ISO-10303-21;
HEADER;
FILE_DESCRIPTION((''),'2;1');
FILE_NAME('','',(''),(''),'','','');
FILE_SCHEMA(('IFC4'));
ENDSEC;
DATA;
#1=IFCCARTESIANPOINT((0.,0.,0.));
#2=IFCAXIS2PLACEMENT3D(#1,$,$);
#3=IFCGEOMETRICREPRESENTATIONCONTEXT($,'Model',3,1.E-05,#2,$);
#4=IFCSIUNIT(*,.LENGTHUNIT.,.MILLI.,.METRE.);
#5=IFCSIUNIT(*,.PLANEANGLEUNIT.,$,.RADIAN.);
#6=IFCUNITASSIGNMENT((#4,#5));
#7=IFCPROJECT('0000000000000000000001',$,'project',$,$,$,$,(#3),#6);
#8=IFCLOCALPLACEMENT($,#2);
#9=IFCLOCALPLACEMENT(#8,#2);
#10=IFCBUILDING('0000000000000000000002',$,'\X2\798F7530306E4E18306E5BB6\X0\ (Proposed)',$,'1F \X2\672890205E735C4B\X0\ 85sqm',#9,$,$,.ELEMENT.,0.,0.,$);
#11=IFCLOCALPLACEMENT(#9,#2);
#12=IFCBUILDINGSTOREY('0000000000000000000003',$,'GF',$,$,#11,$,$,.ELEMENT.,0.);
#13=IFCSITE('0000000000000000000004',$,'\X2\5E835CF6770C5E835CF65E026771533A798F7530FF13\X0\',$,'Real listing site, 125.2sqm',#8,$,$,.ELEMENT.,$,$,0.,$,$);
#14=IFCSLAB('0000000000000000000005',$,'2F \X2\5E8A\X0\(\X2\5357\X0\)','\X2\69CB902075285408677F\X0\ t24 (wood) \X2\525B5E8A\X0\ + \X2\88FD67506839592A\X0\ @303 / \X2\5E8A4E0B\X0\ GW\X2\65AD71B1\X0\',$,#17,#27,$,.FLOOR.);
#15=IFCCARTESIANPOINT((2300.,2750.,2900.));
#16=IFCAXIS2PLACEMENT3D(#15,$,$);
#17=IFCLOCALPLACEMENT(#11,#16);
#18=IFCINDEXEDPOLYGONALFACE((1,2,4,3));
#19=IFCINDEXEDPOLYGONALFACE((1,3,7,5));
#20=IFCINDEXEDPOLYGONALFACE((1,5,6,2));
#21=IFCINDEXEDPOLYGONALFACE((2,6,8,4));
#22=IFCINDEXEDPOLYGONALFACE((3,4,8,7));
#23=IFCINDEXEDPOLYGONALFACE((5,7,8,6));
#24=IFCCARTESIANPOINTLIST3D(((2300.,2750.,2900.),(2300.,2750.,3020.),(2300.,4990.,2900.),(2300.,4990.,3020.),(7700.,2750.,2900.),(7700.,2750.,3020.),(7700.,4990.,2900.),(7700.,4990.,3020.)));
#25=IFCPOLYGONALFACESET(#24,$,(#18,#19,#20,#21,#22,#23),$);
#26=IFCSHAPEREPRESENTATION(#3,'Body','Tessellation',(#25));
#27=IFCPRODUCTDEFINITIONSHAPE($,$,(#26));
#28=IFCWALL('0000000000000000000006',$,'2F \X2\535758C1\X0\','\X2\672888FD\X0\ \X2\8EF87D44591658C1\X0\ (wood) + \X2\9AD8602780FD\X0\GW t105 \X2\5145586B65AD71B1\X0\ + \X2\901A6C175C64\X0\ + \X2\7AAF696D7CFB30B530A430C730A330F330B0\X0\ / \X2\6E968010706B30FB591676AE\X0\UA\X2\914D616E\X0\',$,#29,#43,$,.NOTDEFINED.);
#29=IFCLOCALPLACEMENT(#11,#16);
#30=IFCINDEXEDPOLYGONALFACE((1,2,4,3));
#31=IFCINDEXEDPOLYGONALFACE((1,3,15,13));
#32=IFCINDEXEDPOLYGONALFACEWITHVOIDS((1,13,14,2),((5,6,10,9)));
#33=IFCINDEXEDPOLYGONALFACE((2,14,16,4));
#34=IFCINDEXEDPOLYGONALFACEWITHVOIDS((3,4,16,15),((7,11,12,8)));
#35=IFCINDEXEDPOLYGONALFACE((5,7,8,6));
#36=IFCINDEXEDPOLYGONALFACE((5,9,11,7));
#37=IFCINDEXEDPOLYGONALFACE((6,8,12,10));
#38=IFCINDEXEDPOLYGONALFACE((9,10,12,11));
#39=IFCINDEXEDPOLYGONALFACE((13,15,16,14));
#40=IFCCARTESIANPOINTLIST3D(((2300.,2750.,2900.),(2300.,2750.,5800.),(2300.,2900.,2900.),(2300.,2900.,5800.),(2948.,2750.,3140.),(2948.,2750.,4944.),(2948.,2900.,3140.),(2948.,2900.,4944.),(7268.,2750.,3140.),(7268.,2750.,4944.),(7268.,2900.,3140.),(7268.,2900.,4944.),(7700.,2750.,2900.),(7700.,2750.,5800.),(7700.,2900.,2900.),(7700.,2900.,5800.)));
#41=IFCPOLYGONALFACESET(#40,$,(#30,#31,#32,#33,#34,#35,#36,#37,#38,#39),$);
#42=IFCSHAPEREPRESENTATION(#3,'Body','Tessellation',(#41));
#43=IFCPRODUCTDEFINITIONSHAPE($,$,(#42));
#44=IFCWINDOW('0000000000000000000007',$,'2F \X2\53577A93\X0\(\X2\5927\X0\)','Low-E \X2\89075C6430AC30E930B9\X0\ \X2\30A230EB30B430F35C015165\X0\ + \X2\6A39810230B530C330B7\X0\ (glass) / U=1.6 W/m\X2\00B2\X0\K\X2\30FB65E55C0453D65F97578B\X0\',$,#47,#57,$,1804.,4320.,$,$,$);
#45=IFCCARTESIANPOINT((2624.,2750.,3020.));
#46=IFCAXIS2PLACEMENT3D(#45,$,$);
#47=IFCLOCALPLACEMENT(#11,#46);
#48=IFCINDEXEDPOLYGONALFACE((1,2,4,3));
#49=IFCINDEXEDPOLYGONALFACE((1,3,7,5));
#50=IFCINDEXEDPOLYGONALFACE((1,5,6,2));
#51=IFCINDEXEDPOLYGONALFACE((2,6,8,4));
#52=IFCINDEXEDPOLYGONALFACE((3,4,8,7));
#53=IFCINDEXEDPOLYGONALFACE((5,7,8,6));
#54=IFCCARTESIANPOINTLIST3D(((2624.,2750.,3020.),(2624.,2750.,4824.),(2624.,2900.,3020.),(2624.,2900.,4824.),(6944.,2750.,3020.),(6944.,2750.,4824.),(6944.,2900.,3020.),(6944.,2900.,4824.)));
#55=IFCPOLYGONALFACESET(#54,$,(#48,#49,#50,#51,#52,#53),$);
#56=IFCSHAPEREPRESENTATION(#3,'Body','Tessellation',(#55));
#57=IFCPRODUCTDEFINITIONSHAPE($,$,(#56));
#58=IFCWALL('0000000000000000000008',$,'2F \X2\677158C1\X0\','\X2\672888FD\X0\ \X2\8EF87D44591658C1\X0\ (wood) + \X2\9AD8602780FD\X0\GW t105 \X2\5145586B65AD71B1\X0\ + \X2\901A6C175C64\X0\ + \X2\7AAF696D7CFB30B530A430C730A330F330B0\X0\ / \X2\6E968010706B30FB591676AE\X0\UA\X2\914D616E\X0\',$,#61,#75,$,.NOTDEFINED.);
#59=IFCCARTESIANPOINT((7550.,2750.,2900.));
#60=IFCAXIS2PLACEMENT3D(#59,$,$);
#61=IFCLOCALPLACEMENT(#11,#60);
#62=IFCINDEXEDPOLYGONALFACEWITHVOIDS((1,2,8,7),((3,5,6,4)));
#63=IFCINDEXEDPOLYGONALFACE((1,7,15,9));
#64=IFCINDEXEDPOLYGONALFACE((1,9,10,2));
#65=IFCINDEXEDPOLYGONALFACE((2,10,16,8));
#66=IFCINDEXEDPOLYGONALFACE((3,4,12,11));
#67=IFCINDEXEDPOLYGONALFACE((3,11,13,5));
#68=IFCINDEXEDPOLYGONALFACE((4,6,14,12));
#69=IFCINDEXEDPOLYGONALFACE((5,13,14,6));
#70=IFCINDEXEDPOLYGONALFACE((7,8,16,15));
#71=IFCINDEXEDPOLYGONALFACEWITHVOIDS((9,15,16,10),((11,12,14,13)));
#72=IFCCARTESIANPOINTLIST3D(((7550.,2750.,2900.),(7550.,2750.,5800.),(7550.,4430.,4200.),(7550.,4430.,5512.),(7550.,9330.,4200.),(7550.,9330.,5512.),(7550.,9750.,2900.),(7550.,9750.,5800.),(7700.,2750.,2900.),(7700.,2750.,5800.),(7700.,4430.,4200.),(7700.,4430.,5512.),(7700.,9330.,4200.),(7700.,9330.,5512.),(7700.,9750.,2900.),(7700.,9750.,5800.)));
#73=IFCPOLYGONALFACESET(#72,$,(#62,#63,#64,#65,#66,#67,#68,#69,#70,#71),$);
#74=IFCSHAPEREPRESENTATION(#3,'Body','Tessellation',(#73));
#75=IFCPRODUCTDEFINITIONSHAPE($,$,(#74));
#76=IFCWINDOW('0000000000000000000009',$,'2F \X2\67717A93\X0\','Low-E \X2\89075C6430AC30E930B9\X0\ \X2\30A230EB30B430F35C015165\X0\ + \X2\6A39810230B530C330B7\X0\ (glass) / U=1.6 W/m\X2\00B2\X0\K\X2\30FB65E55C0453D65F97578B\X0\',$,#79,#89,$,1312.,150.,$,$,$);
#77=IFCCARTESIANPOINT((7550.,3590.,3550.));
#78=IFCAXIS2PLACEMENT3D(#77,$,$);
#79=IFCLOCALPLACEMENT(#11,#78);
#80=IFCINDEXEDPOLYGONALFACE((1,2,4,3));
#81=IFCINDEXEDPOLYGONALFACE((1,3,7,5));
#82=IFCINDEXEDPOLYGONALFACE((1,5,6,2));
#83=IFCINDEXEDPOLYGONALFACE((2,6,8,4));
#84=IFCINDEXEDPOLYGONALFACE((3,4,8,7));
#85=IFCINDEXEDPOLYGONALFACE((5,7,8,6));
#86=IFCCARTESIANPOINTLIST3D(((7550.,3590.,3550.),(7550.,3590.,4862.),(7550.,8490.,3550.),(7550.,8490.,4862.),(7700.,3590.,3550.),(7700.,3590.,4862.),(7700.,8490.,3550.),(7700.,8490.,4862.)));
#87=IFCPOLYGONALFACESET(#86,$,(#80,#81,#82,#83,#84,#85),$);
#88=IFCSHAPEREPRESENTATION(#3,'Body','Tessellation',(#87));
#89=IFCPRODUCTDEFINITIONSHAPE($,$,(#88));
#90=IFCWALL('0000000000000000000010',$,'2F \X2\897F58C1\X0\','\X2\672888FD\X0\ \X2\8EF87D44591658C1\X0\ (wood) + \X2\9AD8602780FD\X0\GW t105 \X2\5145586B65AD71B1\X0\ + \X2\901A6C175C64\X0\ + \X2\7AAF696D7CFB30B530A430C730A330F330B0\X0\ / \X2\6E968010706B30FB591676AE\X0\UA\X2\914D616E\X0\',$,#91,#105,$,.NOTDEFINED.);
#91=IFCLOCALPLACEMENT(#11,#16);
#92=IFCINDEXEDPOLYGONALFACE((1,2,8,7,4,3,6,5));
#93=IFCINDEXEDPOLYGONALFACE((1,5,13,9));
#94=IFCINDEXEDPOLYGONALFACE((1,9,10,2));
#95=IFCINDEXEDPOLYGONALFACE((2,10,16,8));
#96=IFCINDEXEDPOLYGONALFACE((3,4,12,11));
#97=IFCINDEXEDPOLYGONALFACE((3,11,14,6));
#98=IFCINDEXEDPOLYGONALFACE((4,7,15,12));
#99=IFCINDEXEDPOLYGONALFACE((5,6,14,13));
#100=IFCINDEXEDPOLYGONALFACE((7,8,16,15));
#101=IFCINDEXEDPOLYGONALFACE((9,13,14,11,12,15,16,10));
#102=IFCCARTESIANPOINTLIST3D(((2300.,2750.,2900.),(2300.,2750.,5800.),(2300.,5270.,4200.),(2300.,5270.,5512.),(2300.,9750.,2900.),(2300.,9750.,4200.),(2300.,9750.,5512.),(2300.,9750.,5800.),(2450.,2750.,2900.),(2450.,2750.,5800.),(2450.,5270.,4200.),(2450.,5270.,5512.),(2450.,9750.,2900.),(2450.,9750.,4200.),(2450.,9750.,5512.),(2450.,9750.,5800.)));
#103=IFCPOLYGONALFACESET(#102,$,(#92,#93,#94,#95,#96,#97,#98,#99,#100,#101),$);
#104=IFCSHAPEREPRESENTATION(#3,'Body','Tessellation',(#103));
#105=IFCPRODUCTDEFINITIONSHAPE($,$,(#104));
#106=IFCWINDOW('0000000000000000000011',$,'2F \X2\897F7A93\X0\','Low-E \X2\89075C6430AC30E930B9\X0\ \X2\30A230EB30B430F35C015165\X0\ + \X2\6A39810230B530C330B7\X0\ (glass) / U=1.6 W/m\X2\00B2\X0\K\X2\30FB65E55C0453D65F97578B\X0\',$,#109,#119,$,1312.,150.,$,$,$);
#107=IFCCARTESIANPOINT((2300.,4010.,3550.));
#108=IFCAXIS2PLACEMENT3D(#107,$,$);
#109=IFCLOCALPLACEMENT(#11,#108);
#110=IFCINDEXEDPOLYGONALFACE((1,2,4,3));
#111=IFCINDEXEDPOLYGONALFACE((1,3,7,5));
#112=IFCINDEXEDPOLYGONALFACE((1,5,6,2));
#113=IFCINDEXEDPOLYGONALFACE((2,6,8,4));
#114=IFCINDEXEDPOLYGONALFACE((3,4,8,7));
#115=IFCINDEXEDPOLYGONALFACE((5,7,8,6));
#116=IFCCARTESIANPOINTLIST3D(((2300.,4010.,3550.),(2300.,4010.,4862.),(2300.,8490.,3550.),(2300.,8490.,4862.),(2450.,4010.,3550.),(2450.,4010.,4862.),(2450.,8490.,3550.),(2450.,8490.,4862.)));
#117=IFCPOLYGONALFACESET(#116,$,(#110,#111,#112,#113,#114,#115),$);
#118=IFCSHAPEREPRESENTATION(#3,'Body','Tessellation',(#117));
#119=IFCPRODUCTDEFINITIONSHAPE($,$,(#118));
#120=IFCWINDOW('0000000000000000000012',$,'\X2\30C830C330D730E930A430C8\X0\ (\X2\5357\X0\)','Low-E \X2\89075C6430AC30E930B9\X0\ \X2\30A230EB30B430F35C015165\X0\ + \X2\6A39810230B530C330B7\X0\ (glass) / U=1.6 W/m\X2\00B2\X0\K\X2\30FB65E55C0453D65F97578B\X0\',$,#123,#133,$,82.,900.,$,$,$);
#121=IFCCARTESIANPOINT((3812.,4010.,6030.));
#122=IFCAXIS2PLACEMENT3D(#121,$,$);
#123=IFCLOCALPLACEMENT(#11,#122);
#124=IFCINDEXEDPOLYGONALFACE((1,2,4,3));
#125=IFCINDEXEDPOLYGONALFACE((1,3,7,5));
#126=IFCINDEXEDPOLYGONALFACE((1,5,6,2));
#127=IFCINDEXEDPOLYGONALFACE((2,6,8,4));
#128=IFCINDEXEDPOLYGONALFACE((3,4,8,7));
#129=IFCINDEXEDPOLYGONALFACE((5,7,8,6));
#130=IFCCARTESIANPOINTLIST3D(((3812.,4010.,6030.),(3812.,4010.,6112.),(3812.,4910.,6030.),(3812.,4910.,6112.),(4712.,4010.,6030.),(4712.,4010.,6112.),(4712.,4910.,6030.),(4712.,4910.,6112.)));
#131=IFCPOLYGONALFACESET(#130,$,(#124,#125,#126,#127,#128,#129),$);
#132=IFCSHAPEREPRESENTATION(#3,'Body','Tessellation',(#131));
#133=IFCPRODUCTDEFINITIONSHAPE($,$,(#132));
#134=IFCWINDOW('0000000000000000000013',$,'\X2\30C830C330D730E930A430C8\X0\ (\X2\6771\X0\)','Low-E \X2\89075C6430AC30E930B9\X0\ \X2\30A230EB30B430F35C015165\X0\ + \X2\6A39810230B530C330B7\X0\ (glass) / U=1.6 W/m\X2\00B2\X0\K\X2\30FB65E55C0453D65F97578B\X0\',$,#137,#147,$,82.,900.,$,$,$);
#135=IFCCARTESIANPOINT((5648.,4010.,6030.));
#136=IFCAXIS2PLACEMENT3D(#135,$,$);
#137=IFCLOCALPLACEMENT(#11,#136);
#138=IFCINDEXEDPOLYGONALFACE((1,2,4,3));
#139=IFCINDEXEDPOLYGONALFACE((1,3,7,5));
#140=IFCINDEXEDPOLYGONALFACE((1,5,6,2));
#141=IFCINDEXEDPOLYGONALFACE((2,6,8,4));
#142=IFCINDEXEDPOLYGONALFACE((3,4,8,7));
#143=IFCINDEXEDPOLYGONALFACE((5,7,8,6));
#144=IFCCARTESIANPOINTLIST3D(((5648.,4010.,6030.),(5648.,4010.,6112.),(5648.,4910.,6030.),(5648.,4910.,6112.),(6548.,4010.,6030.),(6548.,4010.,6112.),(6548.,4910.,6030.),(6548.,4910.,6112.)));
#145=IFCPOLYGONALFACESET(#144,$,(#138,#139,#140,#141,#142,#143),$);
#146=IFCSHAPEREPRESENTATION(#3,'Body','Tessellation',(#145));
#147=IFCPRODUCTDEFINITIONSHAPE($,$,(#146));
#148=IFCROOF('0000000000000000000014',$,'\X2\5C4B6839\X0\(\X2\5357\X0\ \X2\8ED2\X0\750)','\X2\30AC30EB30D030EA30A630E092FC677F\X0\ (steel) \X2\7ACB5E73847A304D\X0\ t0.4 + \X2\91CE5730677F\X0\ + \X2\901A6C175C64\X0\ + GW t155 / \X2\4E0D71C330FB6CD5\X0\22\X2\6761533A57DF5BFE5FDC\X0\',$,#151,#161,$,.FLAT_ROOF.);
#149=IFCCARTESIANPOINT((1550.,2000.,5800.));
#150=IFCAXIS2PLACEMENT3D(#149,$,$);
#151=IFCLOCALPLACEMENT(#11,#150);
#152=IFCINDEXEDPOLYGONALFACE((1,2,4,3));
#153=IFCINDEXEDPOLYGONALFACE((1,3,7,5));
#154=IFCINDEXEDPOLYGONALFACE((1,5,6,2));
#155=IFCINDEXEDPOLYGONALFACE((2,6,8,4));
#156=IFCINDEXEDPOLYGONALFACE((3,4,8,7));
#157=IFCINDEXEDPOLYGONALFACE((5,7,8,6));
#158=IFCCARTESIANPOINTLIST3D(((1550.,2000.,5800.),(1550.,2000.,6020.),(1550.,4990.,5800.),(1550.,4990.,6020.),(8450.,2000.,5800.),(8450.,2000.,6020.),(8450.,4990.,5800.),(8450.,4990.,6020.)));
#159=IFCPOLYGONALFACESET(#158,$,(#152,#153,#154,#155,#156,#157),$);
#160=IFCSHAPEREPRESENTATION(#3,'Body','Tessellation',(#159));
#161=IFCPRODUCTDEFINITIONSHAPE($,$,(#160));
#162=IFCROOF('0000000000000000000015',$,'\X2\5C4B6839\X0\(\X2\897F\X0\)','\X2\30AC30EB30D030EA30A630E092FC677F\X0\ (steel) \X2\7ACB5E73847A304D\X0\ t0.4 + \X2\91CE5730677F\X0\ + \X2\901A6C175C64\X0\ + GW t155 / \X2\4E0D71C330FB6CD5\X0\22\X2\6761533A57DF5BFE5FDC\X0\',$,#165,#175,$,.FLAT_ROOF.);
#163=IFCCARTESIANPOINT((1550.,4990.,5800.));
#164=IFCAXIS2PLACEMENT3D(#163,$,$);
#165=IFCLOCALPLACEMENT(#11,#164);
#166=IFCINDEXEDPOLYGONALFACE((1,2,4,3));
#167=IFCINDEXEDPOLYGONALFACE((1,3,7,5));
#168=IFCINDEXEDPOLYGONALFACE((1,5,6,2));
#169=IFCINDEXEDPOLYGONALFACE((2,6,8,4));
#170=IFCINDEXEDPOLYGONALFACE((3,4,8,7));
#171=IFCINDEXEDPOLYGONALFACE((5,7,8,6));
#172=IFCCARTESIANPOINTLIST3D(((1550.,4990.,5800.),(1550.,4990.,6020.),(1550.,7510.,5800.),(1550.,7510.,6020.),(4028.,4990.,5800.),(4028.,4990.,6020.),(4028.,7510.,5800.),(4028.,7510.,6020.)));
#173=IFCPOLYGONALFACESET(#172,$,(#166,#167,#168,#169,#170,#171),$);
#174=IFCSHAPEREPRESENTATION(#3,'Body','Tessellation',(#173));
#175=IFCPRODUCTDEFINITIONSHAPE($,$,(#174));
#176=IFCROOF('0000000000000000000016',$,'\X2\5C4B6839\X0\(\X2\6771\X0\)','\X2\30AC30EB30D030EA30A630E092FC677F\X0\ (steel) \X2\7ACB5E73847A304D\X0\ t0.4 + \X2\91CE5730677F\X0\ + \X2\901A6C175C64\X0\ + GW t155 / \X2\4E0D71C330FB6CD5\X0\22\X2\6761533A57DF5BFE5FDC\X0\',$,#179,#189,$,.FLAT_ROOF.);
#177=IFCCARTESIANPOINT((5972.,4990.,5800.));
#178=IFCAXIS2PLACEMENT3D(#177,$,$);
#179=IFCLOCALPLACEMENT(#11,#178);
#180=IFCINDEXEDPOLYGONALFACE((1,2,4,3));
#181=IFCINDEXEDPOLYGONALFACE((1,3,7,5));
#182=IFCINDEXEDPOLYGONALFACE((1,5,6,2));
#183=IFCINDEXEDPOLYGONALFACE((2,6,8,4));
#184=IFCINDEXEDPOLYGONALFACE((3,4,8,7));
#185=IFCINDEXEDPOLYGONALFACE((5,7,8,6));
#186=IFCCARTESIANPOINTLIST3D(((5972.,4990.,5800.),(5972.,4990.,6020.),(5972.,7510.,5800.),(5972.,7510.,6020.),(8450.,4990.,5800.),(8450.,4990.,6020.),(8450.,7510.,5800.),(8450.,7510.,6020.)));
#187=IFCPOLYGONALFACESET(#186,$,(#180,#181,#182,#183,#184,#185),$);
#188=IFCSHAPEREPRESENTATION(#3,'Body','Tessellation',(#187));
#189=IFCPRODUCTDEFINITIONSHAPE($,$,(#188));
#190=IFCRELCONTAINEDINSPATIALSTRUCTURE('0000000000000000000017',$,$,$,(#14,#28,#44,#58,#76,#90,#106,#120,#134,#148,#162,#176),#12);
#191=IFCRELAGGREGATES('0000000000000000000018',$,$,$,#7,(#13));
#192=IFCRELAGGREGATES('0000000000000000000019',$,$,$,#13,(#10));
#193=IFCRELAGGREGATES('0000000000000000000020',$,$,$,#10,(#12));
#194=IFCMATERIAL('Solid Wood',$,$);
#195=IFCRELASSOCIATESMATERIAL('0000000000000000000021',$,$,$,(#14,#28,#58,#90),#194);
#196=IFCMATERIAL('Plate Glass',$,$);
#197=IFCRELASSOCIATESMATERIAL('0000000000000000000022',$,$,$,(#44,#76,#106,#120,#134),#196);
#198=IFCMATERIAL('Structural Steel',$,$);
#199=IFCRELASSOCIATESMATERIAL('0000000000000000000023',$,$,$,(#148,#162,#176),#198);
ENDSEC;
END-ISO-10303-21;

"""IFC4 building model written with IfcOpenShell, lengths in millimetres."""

from ifc_helpers import new_model, si_unit, frame, frame_2d, origin, place, context, project, spatial, rectangle, extrude, material, element, fill, save


model = new_model("IFC4")

# Units and contexts
model_context = context("Model", 3, precision=1e-05, world=origin())
ifc_project = project(units=[si_unit("LENGTHUNIT", "METRE", prefix="MILLI"), si_unit("PLANEANGLEUNIT", "RADIAN")], contexts=[model_context])

# Site, building, storey
site_placement = place(None, origin())
site = spatial("IfcSite", under=ifc_project, at=site_placement, Name="広島県広島市東区福田３", ObjectType="Real listing site, 125.2sqm", CompositionType="ELEMENT", RefElevation=0.0)
building_placement = place(site_placement, origin())
building = spatial("IfcBuilding", under=site, at=building_placement, Name="福田の丘の家 (Proposed)", ObjectType="1F 木造平屋 85sqm", CompositionType="ELEMENT", ElevationOfRefHeight=0.0, ElevationOfTerrain=0.0)
storey_placement = place(building_placement, origin())
storey = spatial("IfcBuildingStorey", under=building, at=storey_placement, Name="GF", CompositionType="ELEMENT", Elevation=0.0)

# Slab
ifc_material_1 = material(Name="Solid Wood")
slab_placement = place(storey_placement, frame((2300.0, 2750.0, 2900.0)))
element("IfcSlab", 1, at=slab_placement, inside=storey, material=ifc_material_1, Name="2F 床(南)", Description="構造用合板 t24 (wood) 剛床 + 製材根太 @303 / 床下 GW断熱", PredefinedType="FLOOR", context=model_context, shape_type="SweptSolid", body=[
    extrude(rectangle(XDim=5400.0, YDim=2240.0, at=frame_2d((2700.0, 1120.0))), frame((2300.0, 2750.0, 2900.0)), (0.0, 0.0, 1.0), 120.0),
])

# Walls, openings, windows
wall_1_placement = place(storey_placement, frame((2300.0, 2750.0, 2900.0)))
wall_1 = element("IfcWall", 2, at=wall_1_placement, inside=storey, material=ifc_material_1, Name="2F 南壁", Description="木製 軸組外壁 (wood) + 高性能GW t105 充填断熱 + 通気層 + 窯業系サイディング / 準耐火・外皮UA配慮", PredefinedType="NOTDEFINED", context=model_context, shape_type="SweptSolid", body=[
    extrude(rectangle(XDim=5400.0, YDim=150.0, at=frame_2d((2700.0, 75.0))), frame((2300.0, 2750.0, 2900.0)), (0.0, 0.0, 1.0), 2900.0),
])
opening_1_placement = place(storey_placement, frame((2624.0, 2750.0, 3020.0)))
opening_1 = element("IfcOpeningElement", 3, at=opening_1_placement, cuts=wall_1, PredefinedType="NOTDEFINED", context=model_context, shape_type="SweptSolid", body=[
    extrude(rectangle(XDim=4320.0, YDim=150.0, at=frame_2d((2160.0, 75.0))), frame((2624.0, 2750.0, 3020.0)), (0.0, 0.0, 1.0), 1804.0),
])
ifc_material_2 = material(Name="Plate Glass")
window_1_placement = place(storey_placement, frame((2624.0, 2750.0, 3020.0)))
window_1 = element("IfcWindow", 4, at=window_1_placement, inside=storey, material=ifc_material_2, Name="2F 南窓(大)", Description="Low-E 複層ガラス アルゴン封入 + 樹脂サッシ (glass) / U=1.6 W/m²K・日射取得型", OverallHeight=1804.0, OverallWidth=4320.0, context=model_context, shape_type="SweptSolid", body=[
    extrude(rectangle(XDim=4320.0, YDim=150.0, at=frame_2d((2160.0, 75.0))), frame((2624.0, 2750.0, 3020.0)), (0.0, 0.0, 1.0), 1804.0),
])
fill(opening_1, window_1)
wall_2_placement = place(storey_placement, frame((7550.0, 2750.0, 2900.0)))
wall_2 = element("IfcWall", 5, at=wall_2_placement, inside=storey, material=ifc_material_1, Name="2F 東壁", Description="木製 軸組外壁 (wood) + 高性能GW t105 充填断熱 + 通気層 + 窯業系サイディング / 準耐火・外皮UA配慮", PredefinedType="NOTDEFINED", context=model_context, shape_type="SweptSolid", body=[
    extrude(rectangle(XDim=150.0, YDim=7000.0, at=frame_2d((75.0, 3500.0))), frame((7550.0, 2750.0, 2900.0)), (0.0, 0.0, 1.0), 2900.0),
])
opening_2_placement = place(storey_placement, frame((7550.0, 3590.0, 3550.0)))
opening_2 = element("IfcOpeningElement", 6, at=opening_2_placement, cuts=wall_2, PredefinedType="NOTDEFINED", context=model_context, shape_type="SweptSolid", body=[
    extrude(rectangle(XDim=150.0, YDim=4900.0, at=frame_2d((75.0, 2450.0))), frame((7550.0, 3590.0, 3550.0)), (0.0, 0.0, 1.0), 1312.0),
])
window_2_placement = place(storey_placement, frame((7550.0, 3590.0, 3550.0)))
window_2 = element("IfcWindow", 7, at=window_2_placement, inside=storey, material=ifc_material_2, Name="2F 東窓", Description="Low-E 複層ガラス アルゴン封入 + 樹脂サッシ (glass) / U=1.6 W/m²K・日射取得型", OverallHeight=1312.0, OverallWidth=150.0, context=model_context, shape_type="SweptSolid", body=[
    extrude(rectangle(XDim=150.0, YDim=4900.0, at=frame_2d((75.0, 2450.0))), frame((7550.0, 3590.0, 3550.0)), (0.0, 0.0, 1.0), 1312.0),
])
fill(opening_2, window_2)
wall_3_placement = place(storey_placement, frame((2300.0, 2750.0, 2900.0)))
wall_3 = element("IfcWall", 8, at=wall_3_placement, inside=storey, material=ifc_material_1, Name="2F 西壁", Description="木製 軸組外壁 (wood) + 高性能GW t105 充填断熱 + 通気層 + 窯業系サイディング / 準耐火・外皮UA配慮", PredefinedType="NOTDEFINED", context=model_context, shape_type="SweptSolid", body=[
    extrude(rectangle(XDim=150.0, YDim=7000.0, at=frame_2d((75.0, 3500.0))), frame((2300.0, 2750.0, 2900.0)), (0.0, 0.0, 1.0), 2900.0),
])
opening_3_placement = place(storey_placement, frame((2300.0, 4010.0, 3550.0)))
opening_3 = element("IfcOpeningElement", 9, at=opening_3_placement, cuts=wall_3, PredefinedType="NOTDEFINED", context=model_context, shape_type="SweptSolid", body=[
    extrude(rectangle(XDim=150.0, YDim=4480.0, at=frame_2d((75.0, 2240.0))), frame((2300.0, 4010.0, 3550.0)), (0.0, 0.0, 1.0), 1312.0),
])
window_3_placement = place(storey_placement, frame((2300.0, 4010.0, 3550.0)))
window_3 = element("IfcWindow", 10, at=window_3_placement, inside=storey, material=ifc_material_2, Name="2F 西窓", Description="Low-E 複層ガラス アルゴン封入 + 樹脂サッシ (glass) / U=1.6 W/m²K・日射取得型", OverallHeight=1312.0, OverallWidth=150.0, context=model_context, shape_type="SweptSolid", body=[
    extrude(rectangle(XDim=150.0, YDim=4480.0, at=frame_2d((75.0, 2240.0))), frame((2300.0, 4010.0, 3550.0)), (0.0, 0.0, 1.0), 1312.0),
])
fill(opening_3, window_3)

# Windows
window_4_placement = place(storey_placement, frame((3812.0, 4010.0, 6030.0)))
element("IfcWindow", 11, at=window_4_placement, inside=storey, material=ifc_material_2, Name="トップライト (南)", Description="Low-E 複層ガラス アルゴン封入 + 樹脂サッシ (glass) / U=1.6 W/m²K・日射取得型", OverallHeight=82.0, OverallWidth=900.0, context=model_context, shape_type="SweptSolid", body=[
    extrude(rectangle(XDim=900.0, YDim=900.0, at=frame_2d((450.0, 450.0))), frame((3812.0, 4010.0, 6030.0)), (0.0, 0.0, 1.0), 82.0),
])
window_5_placement = place(storey_placement, frame((5648.0, 4010.0, 6030.0)))
element("IfcWindow", 12, at=window_5_placement, inside=storey, material=ifc_material_2, Name="トップライト (東)", Description="Low-E 複層ガラス アルゴン封入 + 樹脂サッシ (glass) / U=1.6 W/m²K・日射取得型", OverallHeight=82.0, OverallWidth=900.0, context=model_context, shape_type="SweptSolid", body=[
    extrude(rectangle(XDim=900.0, YDim=900.0, at=frame_2d((450.0, 450.0))), frame((5648.0, 4010.0, 6030.0)), (0.0, 0.0, 1.0), 82.0),
])

# Roofs
ifc_material_3 = material(Name="Structural Steel")
roof_1_placement = place(storey_placement, frame((1550.0, 2000.0, 5800.0)))
element("IfcRoof", 13, at=roof_1_placement, inside=storey, material=ifc_material_3, Name="屋根(南 軒750)", Description="ガルバリウム鋼板 (steel) 立平葺き t0.4 + 野地板 + 通気層 + GW t155 / 不燃・法22条区域対応", PredefinedType="FLAT_ROOF", context=model_context, shape_type="SweptSolid", body=[
    extrude(rectangle(XDim=6900.0, YDim=2990.0, at=frame_2d((3450.0, 1495.0))), frame((1550.0, 2000.0, 5800.0)), (0.0, 0.0, 1.0), 220.0),
])
roof_2_placement = place(storey_placement, frame((1550.0, 4990.0, 5800.0)))
element("IfcRoof", 14, at=roof_2_placement, inside=storey, material=ifc_material_3, Name="屋根(西)", Description="ガルバリウム鋼板 (steel) 立平葺き t0.4 + 野地板 + 通気層 + GW t155 / 不燃・法22条区域対応", PredefinedType="FLAT_ROOF", context=model_context, shape_type="SweptSolid", body=[
    extrude(rectangle(XDim=2478.0, YDim=2520.0, at=frame_2d((1239.0, 1260.0))), frame((1550.0, 4990.0, 5800.0)), (0.0, 0.0, 1.0), 220.0),
])
roof_3_placement = place(storey_placement, frame((5972.0, 4990.0, 5800.0)))
element("IfcRoof", 15, at=roof_3_placement, inside=storey, material=ifc_material_3, Name="屋根(東)", Description="ガルバリウム鋼板 (steel) 立平葺き t0.4 + 野地板 + 通気層 + GW t155 / 不燃・法22条区域対応", PredefinedType="FLAT_ROOF", context=model_context, shape_type="SweptSolid", body=[
    extrude(rectangle(XDim=2478.0, YDim=2520.0, at=frame_2d((1239.0, 1260.0))), frame((5972.0, 4990.0, 5800.0)), (0.0, 0.0, 1.0), 220.0),
])

save(model, "model.ifc")
